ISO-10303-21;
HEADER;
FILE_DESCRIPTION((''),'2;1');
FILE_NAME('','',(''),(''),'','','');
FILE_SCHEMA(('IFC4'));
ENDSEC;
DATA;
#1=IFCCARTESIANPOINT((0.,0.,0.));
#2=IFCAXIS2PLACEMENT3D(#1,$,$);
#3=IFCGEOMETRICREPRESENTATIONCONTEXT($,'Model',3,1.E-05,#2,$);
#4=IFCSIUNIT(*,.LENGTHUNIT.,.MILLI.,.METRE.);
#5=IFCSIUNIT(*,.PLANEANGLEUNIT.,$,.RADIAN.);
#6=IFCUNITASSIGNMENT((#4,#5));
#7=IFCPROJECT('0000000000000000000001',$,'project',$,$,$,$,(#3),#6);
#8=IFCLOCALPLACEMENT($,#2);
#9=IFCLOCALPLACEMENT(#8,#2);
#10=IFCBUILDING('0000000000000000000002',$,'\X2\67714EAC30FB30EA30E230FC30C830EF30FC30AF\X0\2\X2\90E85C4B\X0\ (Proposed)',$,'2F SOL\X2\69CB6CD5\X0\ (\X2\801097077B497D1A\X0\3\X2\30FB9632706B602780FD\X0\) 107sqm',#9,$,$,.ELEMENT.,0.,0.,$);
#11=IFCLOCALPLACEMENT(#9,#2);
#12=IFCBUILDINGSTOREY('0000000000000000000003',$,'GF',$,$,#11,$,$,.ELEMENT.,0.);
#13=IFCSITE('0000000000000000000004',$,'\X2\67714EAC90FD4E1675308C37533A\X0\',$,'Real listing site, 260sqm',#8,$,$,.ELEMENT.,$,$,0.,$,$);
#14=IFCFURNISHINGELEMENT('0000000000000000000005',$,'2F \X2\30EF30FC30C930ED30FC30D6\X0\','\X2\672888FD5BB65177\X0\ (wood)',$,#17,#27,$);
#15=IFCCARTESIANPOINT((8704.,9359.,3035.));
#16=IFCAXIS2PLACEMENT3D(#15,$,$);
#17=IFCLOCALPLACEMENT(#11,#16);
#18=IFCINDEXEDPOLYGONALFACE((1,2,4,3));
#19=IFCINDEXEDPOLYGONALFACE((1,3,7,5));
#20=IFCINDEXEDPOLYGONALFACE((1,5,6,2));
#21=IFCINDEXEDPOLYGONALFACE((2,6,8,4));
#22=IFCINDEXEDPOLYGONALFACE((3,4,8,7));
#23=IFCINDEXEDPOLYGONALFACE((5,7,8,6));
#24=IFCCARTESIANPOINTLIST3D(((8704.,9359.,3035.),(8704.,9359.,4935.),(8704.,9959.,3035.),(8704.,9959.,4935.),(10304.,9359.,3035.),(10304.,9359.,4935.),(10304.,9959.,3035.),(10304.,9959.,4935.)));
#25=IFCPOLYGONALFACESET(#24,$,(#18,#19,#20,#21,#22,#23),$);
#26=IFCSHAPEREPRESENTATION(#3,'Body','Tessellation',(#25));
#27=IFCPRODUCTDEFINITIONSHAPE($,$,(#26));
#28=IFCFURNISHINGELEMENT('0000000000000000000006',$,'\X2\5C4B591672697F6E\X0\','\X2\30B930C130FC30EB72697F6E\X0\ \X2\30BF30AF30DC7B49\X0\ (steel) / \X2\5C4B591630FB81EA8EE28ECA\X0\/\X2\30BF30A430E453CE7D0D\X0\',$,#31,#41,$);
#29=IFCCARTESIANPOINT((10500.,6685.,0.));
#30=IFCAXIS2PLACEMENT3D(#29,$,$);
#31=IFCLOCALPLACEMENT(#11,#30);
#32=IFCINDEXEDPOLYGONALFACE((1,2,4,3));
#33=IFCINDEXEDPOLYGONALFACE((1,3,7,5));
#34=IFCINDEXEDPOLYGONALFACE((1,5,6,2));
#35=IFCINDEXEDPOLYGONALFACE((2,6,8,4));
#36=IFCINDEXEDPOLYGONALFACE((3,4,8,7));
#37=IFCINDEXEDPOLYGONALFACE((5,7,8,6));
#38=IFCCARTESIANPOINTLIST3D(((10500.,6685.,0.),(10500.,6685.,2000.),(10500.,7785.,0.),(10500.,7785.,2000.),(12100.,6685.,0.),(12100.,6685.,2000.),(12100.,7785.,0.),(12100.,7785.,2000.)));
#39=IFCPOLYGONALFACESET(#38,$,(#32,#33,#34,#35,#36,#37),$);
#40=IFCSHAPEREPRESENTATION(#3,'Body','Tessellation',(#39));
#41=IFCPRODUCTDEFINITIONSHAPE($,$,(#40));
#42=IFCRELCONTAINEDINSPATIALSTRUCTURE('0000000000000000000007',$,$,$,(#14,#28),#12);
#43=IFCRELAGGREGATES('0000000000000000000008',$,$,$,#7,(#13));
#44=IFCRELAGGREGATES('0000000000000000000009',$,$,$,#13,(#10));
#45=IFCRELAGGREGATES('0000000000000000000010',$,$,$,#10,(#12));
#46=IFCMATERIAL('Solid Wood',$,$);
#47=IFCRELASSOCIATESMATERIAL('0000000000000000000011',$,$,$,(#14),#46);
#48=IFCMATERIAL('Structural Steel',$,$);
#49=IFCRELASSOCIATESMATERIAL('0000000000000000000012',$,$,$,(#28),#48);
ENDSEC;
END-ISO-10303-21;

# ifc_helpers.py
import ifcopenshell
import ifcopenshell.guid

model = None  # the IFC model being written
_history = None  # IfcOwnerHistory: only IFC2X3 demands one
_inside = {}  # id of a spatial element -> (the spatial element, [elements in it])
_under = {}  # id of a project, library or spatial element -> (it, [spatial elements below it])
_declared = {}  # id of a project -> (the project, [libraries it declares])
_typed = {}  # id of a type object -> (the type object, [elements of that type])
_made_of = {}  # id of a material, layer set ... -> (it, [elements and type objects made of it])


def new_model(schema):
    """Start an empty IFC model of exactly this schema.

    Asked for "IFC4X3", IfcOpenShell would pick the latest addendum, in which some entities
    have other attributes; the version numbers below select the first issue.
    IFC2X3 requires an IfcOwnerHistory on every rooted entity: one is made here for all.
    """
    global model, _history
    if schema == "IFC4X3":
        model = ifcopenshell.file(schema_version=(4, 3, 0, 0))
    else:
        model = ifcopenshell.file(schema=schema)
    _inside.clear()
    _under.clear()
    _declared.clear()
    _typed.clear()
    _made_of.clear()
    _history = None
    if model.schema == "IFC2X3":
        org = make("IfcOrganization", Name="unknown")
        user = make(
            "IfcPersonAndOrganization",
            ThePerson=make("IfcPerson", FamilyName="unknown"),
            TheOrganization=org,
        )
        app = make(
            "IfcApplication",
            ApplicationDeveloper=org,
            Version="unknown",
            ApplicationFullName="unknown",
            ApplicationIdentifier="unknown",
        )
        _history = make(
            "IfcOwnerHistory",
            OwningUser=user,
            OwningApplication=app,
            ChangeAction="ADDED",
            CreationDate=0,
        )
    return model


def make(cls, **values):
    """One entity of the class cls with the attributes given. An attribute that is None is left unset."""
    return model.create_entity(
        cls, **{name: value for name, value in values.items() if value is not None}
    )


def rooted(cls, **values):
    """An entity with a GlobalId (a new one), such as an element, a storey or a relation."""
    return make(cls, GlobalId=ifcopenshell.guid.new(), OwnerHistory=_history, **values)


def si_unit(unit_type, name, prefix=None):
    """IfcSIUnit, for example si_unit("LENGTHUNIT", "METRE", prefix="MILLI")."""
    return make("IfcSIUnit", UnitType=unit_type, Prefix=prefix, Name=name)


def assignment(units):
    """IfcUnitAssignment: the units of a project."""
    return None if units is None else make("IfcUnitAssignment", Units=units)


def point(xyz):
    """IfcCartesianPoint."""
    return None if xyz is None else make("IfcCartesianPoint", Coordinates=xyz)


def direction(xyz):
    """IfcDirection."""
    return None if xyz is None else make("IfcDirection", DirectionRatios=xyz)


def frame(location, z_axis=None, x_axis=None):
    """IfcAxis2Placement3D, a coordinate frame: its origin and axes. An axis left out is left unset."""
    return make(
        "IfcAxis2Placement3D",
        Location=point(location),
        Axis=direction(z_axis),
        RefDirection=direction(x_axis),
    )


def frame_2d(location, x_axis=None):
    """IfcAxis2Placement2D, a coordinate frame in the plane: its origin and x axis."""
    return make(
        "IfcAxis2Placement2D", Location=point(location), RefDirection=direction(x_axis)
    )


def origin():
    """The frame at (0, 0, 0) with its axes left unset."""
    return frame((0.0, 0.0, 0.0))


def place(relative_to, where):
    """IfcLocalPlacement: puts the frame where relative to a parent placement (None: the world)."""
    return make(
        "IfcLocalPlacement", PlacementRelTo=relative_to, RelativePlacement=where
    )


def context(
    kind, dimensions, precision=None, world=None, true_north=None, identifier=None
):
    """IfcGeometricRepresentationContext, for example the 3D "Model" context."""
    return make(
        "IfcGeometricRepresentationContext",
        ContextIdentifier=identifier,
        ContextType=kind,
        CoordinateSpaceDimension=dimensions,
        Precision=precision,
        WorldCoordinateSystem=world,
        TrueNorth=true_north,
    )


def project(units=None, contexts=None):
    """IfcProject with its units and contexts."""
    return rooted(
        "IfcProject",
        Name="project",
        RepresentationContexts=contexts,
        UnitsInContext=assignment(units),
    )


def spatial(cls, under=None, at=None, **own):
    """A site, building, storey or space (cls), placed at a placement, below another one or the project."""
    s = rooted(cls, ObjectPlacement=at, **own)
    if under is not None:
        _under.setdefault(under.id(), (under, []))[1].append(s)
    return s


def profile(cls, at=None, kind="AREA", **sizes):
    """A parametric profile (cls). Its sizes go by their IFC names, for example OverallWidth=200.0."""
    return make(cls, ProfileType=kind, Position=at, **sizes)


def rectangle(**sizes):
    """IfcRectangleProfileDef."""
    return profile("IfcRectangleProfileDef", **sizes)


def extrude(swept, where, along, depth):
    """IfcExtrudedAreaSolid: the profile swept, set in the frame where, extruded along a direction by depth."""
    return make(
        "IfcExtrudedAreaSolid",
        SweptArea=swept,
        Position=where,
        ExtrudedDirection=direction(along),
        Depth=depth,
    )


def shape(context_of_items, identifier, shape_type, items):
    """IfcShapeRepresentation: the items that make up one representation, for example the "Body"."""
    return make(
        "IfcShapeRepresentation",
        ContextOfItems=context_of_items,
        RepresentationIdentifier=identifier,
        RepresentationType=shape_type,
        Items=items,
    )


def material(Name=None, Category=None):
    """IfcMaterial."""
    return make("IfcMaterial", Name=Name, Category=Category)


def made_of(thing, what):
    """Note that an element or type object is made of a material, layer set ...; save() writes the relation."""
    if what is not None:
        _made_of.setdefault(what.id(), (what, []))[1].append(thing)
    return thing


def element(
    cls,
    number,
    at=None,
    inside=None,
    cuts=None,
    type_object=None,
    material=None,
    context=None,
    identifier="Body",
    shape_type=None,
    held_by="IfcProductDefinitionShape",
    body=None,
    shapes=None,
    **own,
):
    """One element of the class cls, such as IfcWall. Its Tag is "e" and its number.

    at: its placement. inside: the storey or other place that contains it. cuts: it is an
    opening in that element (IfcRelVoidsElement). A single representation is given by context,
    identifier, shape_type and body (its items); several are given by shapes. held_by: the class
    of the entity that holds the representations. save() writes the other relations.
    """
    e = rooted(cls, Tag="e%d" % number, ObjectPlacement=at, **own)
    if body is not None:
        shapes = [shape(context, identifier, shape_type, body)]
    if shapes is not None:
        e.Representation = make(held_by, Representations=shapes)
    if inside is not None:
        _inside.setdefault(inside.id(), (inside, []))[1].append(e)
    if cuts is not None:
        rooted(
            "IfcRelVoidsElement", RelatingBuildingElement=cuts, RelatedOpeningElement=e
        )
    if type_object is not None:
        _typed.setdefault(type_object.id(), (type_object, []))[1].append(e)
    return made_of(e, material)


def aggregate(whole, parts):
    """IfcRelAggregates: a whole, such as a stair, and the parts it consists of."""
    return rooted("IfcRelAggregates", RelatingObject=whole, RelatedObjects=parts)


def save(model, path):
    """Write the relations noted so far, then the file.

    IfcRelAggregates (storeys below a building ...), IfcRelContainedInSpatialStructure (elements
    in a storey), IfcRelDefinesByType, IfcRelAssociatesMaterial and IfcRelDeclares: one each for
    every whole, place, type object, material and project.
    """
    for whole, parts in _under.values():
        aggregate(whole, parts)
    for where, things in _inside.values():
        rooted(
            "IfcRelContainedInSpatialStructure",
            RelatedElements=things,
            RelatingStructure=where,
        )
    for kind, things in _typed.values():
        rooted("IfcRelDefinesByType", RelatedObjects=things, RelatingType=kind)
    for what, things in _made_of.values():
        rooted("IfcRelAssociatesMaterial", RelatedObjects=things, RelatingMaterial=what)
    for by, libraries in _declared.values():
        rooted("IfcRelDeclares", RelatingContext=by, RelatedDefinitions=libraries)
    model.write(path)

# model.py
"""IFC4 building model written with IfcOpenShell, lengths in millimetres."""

from ifc_helpers import new_model, si_unit, frame, frame_2d, origin, place, context, project, spatial, rectangle, extrude, material, element, save


model = new_model("IFC4")

# Units and contexts
model_context = context("Model", 3, precision=1e-05, world=origin())
ifc_project = project(units=[si_unit("LENGTHUNIT", "METRE", prefix="MILLI"), si_unit("PLANEANGLEUNIT", "RADIAN")], contexts=[model_context])

# Site, building, storey
site_placement = place(None, origin())
site = spatial("IfcSite", under=ifc_project, at=site_placement, Name="東京都世田谷区", ObjectType="Real listing site, 260sqm", CompositionType="ELEMENT", RefElevation=0.0)
building_placement = place(site_placement, origin())
building = spatial("IfcBuilding", under=site, at=building_placement, Name="東京・リモートワーク2部屋 (Proposed)", ObjectType="2F SOL構法 (耐震等級3・防火性能) 107sqm", CompositionType="ELEMENT", ElevationOfRefHeight=0.0, ElevationOfTerrain=0.0)
storey_placement = place(building_placement, origin())
storey = spatial("IfcBuildingStorey", under=building, at=storey_placement, Name="GF", CompositionType="ELEMENT", Elevation=0.0)

# Shared definitions
ifc_material_1 = material(Name="Solid Wood")

# Shared definitions
ifc_material_2 = material(Name="Structural Steel")

# Furnishing elements
furnishing_1_placement = place(storey_placement, frame((8704.0, 9359.0, 3035.0)))
element("IfcFurnishingElement", 1, at=furnishing_1_placement, inside=storey, material=ifc_material_1, Name="2F ワードローブ", Description="木製家具 (wood)", context=model_context, shape_type="SweptSolid", body=[
    extrude(rectangle(XDim=1600.0, YDim=600.0, at=frame_2d((800.0, 300.0))), frame((8704.0, 9359.0, 3035.0)), (0.0, 0.0, 1.0), 1900.0),
])
furnishing_2_placement = place(storey_placement, frame((10500.0, 6685.0, 0.0)))
element("IfcFurnishingElement", 2, at=furnishing_2_placement, inside=storey, material=ifc_material_2, Name="屋外物置", Description="スチール物置 タクボ等 (steel) / 屋外・自転車/タイヤ収納", context=model_context, shape_type="SweptSolid", body=[
    extrude(rectangle(XDim=1600.0, YDim=1100.0, at=frame_2d((800.0, 550.0))), frame((10500.0, 6685.0, 0.0)), (0.0, 0.0, 1.0), 2000.0),
])

save(model, "model.ifc")
